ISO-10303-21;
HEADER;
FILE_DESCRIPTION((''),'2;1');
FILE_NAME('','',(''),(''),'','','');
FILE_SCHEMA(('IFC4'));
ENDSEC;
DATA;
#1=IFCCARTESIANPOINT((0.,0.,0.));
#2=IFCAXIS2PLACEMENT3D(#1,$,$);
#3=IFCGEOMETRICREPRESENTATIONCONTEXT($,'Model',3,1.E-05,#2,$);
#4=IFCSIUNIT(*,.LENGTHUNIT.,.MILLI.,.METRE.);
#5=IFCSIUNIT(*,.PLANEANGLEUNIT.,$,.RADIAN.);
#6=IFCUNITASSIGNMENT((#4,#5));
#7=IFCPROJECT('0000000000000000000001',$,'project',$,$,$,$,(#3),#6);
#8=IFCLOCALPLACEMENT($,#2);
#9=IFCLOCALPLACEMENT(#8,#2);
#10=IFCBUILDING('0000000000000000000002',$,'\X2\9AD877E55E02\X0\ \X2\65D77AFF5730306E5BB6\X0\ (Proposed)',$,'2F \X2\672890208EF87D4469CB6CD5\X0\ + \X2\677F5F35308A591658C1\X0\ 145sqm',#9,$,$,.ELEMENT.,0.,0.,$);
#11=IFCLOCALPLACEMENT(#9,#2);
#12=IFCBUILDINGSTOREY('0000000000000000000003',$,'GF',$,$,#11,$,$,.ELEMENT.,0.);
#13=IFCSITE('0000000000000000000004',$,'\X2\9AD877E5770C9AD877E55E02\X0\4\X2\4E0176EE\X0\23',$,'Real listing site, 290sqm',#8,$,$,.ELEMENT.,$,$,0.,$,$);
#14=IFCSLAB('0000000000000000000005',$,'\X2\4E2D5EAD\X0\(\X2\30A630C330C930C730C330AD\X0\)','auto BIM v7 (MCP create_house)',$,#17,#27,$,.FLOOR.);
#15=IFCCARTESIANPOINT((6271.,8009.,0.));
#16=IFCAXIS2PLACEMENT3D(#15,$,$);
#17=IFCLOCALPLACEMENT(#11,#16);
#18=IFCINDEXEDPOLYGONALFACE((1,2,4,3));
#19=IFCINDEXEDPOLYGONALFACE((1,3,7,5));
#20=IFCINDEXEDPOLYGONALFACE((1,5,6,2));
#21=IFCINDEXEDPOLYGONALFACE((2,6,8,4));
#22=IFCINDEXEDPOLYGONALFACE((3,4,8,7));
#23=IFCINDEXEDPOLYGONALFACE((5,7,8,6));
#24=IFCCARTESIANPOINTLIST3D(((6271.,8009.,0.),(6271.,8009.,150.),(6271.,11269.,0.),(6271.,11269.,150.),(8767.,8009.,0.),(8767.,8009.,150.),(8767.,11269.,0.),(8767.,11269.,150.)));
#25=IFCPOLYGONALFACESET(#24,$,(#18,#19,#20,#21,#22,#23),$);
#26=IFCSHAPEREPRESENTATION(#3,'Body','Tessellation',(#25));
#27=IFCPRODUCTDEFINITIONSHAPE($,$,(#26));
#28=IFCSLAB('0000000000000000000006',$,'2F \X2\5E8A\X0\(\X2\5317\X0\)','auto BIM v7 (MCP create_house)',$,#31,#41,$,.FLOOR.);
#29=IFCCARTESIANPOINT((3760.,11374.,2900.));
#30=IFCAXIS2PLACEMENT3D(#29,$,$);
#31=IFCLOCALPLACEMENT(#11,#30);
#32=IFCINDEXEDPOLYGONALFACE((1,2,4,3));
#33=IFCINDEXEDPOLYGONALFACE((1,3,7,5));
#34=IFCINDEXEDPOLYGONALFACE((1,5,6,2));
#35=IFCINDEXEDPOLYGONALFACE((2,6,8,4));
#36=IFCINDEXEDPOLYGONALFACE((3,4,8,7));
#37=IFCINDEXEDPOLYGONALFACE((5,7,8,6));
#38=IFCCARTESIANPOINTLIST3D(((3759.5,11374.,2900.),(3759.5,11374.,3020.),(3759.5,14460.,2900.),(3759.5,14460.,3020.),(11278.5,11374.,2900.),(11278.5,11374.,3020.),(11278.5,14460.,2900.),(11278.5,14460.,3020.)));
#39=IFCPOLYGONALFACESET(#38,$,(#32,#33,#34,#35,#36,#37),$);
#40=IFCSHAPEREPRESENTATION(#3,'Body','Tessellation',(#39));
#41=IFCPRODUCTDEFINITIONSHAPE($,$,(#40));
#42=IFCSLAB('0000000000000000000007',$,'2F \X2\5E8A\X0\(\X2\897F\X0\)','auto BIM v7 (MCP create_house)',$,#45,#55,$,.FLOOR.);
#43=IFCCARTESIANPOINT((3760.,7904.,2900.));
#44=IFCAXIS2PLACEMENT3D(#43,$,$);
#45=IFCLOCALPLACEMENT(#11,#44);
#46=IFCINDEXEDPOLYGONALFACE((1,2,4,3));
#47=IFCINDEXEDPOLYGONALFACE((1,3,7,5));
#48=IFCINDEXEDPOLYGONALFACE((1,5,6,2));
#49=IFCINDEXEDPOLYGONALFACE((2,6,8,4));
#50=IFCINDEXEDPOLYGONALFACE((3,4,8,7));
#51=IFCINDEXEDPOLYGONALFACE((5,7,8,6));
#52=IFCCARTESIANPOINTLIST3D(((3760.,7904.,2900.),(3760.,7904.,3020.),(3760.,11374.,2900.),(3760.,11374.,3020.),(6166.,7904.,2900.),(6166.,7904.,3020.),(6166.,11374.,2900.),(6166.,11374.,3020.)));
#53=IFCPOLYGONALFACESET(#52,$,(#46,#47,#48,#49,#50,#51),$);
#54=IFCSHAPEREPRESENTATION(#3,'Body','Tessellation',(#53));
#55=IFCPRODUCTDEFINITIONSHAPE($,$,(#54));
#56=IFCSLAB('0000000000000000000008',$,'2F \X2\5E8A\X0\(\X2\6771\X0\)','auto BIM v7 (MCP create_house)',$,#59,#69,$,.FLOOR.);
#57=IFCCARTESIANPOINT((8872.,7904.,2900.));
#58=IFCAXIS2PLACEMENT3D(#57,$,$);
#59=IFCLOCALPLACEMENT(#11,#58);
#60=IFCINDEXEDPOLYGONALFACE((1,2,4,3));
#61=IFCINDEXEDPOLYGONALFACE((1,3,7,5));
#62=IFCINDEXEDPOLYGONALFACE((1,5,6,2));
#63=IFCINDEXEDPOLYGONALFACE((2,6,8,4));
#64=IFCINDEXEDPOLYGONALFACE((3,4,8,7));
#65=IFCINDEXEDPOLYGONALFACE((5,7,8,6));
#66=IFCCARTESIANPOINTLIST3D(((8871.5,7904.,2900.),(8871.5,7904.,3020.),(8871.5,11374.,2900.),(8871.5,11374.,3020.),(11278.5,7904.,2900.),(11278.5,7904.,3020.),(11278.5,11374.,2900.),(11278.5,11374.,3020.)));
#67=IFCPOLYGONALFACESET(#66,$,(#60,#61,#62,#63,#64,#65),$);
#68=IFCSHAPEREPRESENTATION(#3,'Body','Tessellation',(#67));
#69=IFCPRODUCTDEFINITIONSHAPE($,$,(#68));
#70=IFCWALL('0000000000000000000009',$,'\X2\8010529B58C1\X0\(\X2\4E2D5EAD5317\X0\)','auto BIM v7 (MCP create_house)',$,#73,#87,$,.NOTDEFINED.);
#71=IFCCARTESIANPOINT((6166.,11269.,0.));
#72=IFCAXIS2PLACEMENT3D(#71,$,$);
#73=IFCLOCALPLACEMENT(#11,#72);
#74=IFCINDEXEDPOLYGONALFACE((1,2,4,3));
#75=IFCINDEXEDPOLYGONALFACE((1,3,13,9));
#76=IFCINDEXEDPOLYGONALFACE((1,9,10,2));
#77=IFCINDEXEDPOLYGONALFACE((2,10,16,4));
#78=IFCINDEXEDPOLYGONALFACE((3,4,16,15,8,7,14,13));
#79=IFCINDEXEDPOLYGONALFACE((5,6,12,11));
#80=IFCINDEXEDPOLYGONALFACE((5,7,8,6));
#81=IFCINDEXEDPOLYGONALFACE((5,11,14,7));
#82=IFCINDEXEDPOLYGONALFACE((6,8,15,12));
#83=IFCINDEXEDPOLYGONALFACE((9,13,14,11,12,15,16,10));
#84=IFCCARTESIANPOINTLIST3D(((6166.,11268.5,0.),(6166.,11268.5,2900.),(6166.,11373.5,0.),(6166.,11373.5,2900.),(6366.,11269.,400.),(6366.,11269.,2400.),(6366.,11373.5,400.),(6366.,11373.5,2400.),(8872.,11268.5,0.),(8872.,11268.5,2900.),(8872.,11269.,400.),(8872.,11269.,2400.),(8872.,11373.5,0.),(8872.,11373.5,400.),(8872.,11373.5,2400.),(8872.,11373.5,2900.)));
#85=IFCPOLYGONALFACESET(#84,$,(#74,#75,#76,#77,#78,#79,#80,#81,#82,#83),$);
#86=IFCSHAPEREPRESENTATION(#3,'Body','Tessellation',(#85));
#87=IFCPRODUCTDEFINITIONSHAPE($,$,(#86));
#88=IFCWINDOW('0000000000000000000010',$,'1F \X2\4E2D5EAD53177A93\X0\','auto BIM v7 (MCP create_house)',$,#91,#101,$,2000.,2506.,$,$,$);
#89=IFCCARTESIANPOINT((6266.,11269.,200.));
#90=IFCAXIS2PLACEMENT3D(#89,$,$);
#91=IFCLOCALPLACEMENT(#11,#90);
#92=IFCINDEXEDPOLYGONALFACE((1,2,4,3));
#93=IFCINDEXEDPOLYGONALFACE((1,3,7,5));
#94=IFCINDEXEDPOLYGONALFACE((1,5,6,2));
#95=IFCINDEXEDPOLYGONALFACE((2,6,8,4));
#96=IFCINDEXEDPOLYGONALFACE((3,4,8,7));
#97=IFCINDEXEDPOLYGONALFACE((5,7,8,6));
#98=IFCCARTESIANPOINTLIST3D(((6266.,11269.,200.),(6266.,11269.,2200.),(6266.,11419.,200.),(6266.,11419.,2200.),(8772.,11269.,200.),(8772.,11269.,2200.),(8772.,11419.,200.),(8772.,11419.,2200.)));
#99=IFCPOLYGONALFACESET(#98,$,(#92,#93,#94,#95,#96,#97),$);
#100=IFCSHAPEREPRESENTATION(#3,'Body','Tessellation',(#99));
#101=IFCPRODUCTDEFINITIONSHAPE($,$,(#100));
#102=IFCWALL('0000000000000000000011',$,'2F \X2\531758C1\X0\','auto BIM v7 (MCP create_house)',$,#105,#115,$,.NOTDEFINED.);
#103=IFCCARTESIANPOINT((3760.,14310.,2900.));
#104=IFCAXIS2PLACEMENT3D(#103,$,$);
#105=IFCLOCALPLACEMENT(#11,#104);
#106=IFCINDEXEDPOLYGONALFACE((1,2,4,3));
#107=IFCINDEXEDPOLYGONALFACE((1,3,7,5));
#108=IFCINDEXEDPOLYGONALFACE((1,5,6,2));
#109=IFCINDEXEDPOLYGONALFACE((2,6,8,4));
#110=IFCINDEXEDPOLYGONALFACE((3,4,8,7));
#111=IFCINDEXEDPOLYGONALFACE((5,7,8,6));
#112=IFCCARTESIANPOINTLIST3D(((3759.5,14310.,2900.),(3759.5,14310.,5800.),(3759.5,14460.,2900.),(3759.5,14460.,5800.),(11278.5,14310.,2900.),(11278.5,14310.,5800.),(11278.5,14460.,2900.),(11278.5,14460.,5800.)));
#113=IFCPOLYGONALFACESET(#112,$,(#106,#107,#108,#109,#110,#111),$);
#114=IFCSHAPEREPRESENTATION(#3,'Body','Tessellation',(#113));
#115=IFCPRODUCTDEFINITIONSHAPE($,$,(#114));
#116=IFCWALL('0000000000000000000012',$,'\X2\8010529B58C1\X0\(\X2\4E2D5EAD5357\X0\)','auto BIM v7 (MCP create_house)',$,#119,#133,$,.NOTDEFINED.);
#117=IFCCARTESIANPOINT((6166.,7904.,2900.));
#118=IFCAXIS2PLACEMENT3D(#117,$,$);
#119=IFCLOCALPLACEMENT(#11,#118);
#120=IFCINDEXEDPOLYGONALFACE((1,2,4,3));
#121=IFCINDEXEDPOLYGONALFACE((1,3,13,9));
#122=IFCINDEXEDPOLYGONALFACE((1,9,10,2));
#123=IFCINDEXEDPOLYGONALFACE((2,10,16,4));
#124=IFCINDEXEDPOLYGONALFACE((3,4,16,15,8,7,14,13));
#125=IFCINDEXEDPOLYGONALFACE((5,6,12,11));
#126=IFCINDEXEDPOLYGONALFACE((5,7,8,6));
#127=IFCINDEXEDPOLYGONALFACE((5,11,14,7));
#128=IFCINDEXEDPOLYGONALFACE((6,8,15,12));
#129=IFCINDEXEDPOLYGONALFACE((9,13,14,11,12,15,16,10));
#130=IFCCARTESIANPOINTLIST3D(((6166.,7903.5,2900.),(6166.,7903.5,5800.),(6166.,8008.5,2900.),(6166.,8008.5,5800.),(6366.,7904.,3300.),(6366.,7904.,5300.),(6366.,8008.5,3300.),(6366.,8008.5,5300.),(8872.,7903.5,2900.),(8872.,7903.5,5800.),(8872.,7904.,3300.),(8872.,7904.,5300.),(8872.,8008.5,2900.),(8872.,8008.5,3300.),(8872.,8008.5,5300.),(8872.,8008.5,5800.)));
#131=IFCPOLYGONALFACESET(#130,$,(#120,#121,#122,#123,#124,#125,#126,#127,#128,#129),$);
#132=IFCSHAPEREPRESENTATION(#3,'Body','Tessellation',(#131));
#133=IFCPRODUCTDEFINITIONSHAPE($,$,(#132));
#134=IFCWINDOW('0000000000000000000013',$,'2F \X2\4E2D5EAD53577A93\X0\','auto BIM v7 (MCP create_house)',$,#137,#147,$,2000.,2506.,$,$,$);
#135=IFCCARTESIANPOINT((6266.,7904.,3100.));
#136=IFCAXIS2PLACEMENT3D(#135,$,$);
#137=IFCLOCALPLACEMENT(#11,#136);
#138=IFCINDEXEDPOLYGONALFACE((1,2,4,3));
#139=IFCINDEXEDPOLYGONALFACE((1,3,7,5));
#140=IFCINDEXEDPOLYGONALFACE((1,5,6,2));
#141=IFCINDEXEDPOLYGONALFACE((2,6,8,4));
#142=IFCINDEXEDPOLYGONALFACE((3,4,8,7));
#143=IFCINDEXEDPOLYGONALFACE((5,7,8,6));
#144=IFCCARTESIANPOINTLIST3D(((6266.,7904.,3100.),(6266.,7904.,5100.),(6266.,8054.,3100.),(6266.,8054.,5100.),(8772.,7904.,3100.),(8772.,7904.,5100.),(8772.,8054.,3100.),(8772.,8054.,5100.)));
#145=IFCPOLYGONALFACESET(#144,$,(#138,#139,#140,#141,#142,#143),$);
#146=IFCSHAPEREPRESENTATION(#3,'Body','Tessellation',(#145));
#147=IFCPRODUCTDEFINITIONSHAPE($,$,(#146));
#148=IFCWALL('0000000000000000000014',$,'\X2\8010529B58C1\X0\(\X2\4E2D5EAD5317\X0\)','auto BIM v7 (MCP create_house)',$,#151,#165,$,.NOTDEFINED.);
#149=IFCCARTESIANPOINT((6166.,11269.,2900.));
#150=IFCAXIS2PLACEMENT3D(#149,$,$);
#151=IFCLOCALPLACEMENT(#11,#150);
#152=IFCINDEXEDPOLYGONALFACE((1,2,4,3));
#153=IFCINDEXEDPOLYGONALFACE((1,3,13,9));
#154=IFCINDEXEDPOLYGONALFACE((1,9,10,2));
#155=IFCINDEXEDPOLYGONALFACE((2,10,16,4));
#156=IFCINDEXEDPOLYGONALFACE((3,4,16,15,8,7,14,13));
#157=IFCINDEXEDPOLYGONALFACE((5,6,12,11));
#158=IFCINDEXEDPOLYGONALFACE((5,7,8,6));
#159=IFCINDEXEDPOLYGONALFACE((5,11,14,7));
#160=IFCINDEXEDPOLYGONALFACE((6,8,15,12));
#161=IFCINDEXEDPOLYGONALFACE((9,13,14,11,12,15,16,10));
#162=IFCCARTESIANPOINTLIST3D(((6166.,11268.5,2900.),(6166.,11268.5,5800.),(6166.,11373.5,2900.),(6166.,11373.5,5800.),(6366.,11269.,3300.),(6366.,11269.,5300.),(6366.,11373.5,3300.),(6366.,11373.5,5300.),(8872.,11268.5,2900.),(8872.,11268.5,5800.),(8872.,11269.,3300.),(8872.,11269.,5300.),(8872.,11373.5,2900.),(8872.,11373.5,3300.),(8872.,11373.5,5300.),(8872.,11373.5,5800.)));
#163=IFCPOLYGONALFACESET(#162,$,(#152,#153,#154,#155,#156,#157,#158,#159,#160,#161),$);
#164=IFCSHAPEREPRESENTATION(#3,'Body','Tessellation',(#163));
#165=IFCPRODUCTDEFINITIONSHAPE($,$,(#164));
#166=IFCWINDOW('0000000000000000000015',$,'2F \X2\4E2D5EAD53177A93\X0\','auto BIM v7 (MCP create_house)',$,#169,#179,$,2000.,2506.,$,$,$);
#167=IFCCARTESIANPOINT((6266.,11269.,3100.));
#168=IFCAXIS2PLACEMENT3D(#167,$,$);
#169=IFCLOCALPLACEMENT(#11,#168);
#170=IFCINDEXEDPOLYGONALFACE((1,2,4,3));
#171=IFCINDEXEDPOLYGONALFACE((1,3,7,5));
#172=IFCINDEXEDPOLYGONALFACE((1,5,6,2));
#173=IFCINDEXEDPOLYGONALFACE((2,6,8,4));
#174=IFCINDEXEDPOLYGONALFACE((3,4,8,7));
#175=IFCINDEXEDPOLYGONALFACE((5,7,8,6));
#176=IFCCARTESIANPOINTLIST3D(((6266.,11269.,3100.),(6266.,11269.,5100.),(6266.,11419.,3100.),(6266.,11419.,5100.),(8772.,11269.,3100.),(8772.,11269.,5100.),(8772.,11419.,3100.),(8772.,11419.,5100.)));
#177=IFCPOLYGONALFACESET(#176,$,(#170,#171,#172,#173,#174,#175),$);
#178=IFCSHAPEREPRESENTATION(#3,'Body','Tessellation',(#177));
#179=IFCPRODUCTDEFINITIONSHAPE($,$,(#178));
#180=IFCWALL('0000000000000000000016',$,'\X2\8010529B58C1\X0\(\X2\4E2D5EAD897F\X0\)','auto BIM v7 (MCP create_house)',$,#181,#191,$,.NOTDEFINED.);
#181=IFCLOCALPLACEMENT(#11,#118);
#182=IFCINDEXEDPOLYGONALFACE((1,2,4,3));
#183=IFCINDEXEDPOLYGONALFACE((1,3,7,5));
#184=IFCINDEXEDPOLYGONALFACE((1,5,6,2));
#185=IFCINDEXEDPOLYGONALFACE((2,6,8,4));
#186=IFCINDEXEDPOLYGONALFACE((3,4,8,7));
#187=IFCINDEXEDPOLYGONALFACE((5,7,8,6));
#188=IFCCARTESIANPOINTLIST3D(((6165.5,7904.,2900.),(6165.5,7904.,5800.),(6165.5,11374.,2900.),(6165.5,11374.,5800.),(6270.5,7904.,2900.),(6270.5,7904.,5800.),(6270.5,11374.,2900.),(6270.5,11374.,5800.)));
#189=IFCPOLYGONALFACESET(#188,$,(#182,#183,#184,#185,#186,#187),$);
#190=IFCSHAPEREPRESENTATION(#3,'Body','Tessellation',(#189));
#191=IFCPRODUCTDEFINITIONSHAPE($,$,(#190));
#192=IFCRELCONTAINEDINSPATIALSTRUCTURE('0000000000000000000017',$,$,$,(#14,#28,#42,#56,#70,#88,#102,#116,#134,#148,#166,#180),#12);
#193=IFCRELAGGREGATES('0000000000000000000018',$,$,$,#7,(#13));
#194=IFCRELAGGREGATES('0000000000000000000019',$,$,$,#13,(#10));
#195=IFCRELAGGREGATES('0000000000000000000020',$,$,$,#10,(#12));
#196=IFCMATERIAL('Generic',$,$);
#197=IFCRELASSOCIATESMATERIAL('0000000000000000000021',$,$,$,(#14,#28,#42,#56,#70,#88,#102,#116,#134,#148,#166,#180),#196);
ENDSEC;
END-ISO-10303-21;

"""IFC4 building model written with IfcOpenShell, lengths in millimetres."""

from ifc_helpers import new_model, si_unit, frame, frame_2d, origin, place, context, project, spatial, rectangle, extrude, material, element, fill, save


model = new_model("IFC4")

# Units and contexts
model_context = context("Model", 3, precision=1e-05, world=origin())
ifc_project = project(units=[si_unit("LENGTHUNIT", "METRE", prefix="MILLI"), si_unit("PLANEANGLEUNIT", "RADIAN")], contexts=[model_context])

# Site, building, storey
site_placement = place(None, origin())
site = spatial("IfcSite", under=ifc_project, at=site_placement, Name="高知県高知市4丁目23", ObjectType="Real listing site, 290sqm", CompositionType="ELEMENT", RefElevation=0.0)
building_placement = place(site_placement, origin())
building = spatial("IfcBuilding", under=site, at=building_placement, Name="高知市 旗竿地の家 (Proposed)", ObjectType="2F 木造軸組構法 + 板張り外壁 145sqm", CompositionType="ELEMENT", ElevationOfRefHeight=0.0, ElevationOfTerrain=0.0)
storey_placement = place(building_placement, origin())
storey = spatial("IfcBuildingStorey", under=building, at=storey_placement, Name="GF", CompositionType="ELEMENT", Elevation=0.0)

# Slabs
ifc_material = material(Name="Generic")
slab_1_placement = place(storey_placement, frame((6271.0, 8009.0, 0.0)))
element("IfcSlab", 1, at=slab_1_placement, inside=storey, material=ifc_material, Name="中庭(ウッドデッキ)", Description="auto BIM v7 (MCP create_house)", PredefinedType="FLOOR", context=model_context, shape_type="SweptSolid", body=[
    extrude(rectangle(XDim=2496.0, YDim=3260.0, at=frame_2d((1248.0, 1630.0))), frame((6271.0, 8009.0, 0.0)), (0.0, 0.0, 1.0), 150.0),
])
slab_2_placement = place(storey_placement, frame((3760.0, 11374.0, 2900.0)))
element("IfcSlab", 2, at=slab_2_placement, inside=storey, material=ifc_material, Name="2F 床(北)", Description="auto BIM v7 (MCP create_house)", PredefinedType="FLOOR", context=model_context, shape_type="SweptSolid", body=[
    extrude(rectangle(XDim=7519.0, YDim=3086.0, at=frame_2d((3759.0, 1543.0))), frame((3760.0, 11374.0, 2900.0)), (0.0, 0.0, 1.0), 120.0),
])
slab_3_placement = place(storey_placement, frame((3760.0, 7904.0, 2900.0)))
element("IfcSlab", 3, at=slab_3_placement, inside=storey, material=ifc_material, Name="2F 床(西)", Description="auto BIM v7 (MCP create_house)", PredefinedType="FLOOR", context=model_context, shape_type="SweptSolid", body=[
    extrude(rectangle(XDim=2406.0, YDim=3470.0, at=frame_2d((1203.0, 1735.0))), frame((3760.0, 7904.0, 2900.0)), (0.0, 0.0, 1.0), 120.0),
])
slab_4_placement = place(storey_placement, frame((8872.0, 7904.0, 2900.0)))
element("IfcSlab", 4, at=slab_4_placement, inside=storey, material=ifc_material, Name="2F 床(東)", Description="auto BIM v7 (MCP create_house)", PredefinedType="FLOOR", context=model_context, shape_type="SweptSolid", body=[
    extrude(rectangle(XDim=2407.0, YDim=3470.0, at=frame_2d((1203.0, 1735.0))), frame((8872.0, 7904.0, 2900.0)), (0.0, 0.0, 1.0), 120.0),
])

# Wall, opening, window
wall_1_placement = place(storey_placement, frame((6166.0, 11269.0, 0.0)))
wall_1 = element("IfcWall", 5, at=wall_1_placement, inside=storey, material=ifc_material, Name="耐力壁(中庭北)", Description="auto BIM v7 (MCP create_house)", PredefinedType="NOTDEFINED", context=model_context, shape_type="SweptSolid", body=[
    extrude(rectangle(XDim=2706.0, YDim=105.0, at=frame_2d((1353.0, 52.0))), frame((6166.0, 11269.0, 0.0)), (0.0, 0.0, 1.0), 2900.0),
])
opening_1_placement = place(storey_placement, frame((6266.0, 11269.0, 200.0)))
opening_1 = element("IfcOpeningElement", 6, at=opening_1_placement, cuts=wall_1, PredefinedType="NOTDEFINED", context=model_context, shape_type="SweptSolid", body=[
    extrude(rectangle(XDim=2506.0, YDim=150.0, at=frame_2d((1253.0, 75.0))), frame((6266.0, 11269.0, 200.0)), (0.0, 0.0, 1.0), 2000.0),
])
window_1_placement = place(storey_placement, frame((6266.0, 11269.0, 200.0)))
window_1 = element("IfcWindow", 7, at=window_1_placement, inside=storey, material=ifc_material, Name="1F 中庭北窓", Description="auto BIM v7 (MCP create_house)", OverallHeight=2000.0, OverallWidth=2506.0, context=model_context, shape_type="SweptSolid", body=[
    extrude(rectangle(XDim=2506.0, YDim=150.0, at=frame_2d((1253.0, 75.0))), frame((6266.0, 11269.0, 200.0)), (0.0, 0.0, 1.0), 2000.0),
])
fill(opening_1, window_1)

# Wall
wall_2_placement = place(storey_placement, frame((3760.0, 14310.0, 2900.0)))
element("IfcWall", 8, at=wall_2_placement, inside=storey, material=ifc_material, Name="2F 北壁", Description="auto BIM v7 (MCP create_house)", PredefinedType="NOTDEFINED", context=model_context, shape_type="SweptSolid", body=[
    extrude(rectangle(XDim=7519.0, YDim=150.0, at=frame_2d((3759.0, 75.0))), frame((3760.0, 14310.0, 2900.0)), (0.0, 0.0, 1.0), 2900.0),
])

# Walls, openings, windows
wall_3_placement = place(storey_placement, frame((6166.0, 7904.0, 2900.0)))
wall_3 = element("IfcWall", 9, at=wall_3_placement, inside=storey, material=ifc_material, Name="耐力壁(中庭南)", Description="auto BIM v7 (MCP create_house)", PredefinedType="NOTDEFINED", context=model_context, shape_type="SweptSolid", body=[
    extrude(rectangle(XDim=2706.0, YDim=105.0, at=frame_2d((1353.0, 52.0))), frame((6166.0, 7904.0, 2900.0)), (0.0, 0.0, 1.0), 2900.0),
])
opening_2_placement = place(storey_placement, frame((6266.0, 7904.0, 3100.0)))
opening_2 = element("IfcOpeningElement", 10, at=opening_2_placement, cuts=wall_3, PredefinedType="NOTDEFINED", context=model_context, shape_type="SweptSolid", body=[
    extrude(rectangle(XDim=2506.0, YDim=150.0, at=frame_2d((1253.0, 75.0))), frame((6266.0, 7904.0, 3100.0)), (0.0, 0.0, 1.0), 2000.0),
])
window_2_placement = place(storey_placement, frame((6266.0, 7904.0, 3100.0)))
window_2 = element("IfcWindow", 11, at=window_2_placement, inside=storey, material=ifc_material, Name="2F 中庭南窓", Description="auto BIM v7 (MCP create_house)", OverallHeight=2000.0, OverallWidth=2506.0, context=model_context, shape_type="SweptSolid", body=[
    extrude(rectangle(XDim=2506.0, YDim=150.0, at=frame_2d((1253.0, 75.0))), frame((6266.0, 7904.0, 3100.0)), (0.0, 0.0, 1.0), 2000.0),
])
fill(opening_2, window_2)
wall_4_placement = place(storey_placement, frame((6166.0, 11269.0, 2900.0)))
wall_4 = element("IfcWall", 12, at=wall_4_placement, inside=storey, material=ifc_material, Name="耐力壁(中庭北)", Description="auto BIM v7 (MCP create_house)", PredefinedType="NOTDEFINED", context=model_context, shape_type="SweptSolid", body=[
    extrude(rectangle(XDim=2706.0, YDim=105.0, at=frame_2d((1353.0, 52.0))), frame((6166.0, 11269.0, 2900.0)), (0.0, 0.0, 1.0), 2900.0),
])
opening_3_placement = place(storey_placement, frame((6266.0, 11269.0, 3100.0)))
opening_3 = element("IfcOpeningElement", 13, at=opening_3_placement, cuts=wall_4, PredefinedType="NOTDEFINED", context=model_context, shape_type="SweptSolid", body=[
    extrude(rectangle(XDim=2506.0, YDim=150.0, at=frame_2d((1253.0, 75.0))), frame((6266.0, 11269.0, 3100.0)), (0.0, 0.0, 1.0), 2000.0),
])
window_3_placement = place(storey_placement, frame((6266.0, 11269.0, 3100.0)))
window_3 = element("IfcWindow", 14, at=window_3_placement, inside=storey, material=ifc_material, Name="2F 中庭北窓", Description="auto BIM v7 (MCP create_house)", OverallHeight=2000.0, OverallWidth=2506.0, context=model_context, shape_type="SweptSolid", body=[
    extrude(rectangle(XDim=2506.0, YDim=150.0, at=frame_2d((1253.0, 75.0))), frame((6266.0, 11269.0, 3100.0)), (0.0, 0.0, 1.0), 2000.0),
])
fill(opening_3, window_3)

# Wall
wall_5_placement = place(storey_placement, frame((6166.0, 7904.0, 2900.0)))
element("IfcWall", 15, at=wall_5_placement, inside=storey, material=ifc_material, Name="耐力壁(中庭西)", Description="auto BIM v7 (MCP create_house)", PredefinedType="NOTDEFINED", context=model_context, shape_type="SweptSolid", body=[
    extrude(rectangle(XDim=105.0, YDim=3470.0, at=frame_2d((52.0, 1735.0))), frame((6166.0, 7904.0, 2900.0)), (0.0, 0.0, 1.0), 2900.0),
])

save(model, "model.ifc")
